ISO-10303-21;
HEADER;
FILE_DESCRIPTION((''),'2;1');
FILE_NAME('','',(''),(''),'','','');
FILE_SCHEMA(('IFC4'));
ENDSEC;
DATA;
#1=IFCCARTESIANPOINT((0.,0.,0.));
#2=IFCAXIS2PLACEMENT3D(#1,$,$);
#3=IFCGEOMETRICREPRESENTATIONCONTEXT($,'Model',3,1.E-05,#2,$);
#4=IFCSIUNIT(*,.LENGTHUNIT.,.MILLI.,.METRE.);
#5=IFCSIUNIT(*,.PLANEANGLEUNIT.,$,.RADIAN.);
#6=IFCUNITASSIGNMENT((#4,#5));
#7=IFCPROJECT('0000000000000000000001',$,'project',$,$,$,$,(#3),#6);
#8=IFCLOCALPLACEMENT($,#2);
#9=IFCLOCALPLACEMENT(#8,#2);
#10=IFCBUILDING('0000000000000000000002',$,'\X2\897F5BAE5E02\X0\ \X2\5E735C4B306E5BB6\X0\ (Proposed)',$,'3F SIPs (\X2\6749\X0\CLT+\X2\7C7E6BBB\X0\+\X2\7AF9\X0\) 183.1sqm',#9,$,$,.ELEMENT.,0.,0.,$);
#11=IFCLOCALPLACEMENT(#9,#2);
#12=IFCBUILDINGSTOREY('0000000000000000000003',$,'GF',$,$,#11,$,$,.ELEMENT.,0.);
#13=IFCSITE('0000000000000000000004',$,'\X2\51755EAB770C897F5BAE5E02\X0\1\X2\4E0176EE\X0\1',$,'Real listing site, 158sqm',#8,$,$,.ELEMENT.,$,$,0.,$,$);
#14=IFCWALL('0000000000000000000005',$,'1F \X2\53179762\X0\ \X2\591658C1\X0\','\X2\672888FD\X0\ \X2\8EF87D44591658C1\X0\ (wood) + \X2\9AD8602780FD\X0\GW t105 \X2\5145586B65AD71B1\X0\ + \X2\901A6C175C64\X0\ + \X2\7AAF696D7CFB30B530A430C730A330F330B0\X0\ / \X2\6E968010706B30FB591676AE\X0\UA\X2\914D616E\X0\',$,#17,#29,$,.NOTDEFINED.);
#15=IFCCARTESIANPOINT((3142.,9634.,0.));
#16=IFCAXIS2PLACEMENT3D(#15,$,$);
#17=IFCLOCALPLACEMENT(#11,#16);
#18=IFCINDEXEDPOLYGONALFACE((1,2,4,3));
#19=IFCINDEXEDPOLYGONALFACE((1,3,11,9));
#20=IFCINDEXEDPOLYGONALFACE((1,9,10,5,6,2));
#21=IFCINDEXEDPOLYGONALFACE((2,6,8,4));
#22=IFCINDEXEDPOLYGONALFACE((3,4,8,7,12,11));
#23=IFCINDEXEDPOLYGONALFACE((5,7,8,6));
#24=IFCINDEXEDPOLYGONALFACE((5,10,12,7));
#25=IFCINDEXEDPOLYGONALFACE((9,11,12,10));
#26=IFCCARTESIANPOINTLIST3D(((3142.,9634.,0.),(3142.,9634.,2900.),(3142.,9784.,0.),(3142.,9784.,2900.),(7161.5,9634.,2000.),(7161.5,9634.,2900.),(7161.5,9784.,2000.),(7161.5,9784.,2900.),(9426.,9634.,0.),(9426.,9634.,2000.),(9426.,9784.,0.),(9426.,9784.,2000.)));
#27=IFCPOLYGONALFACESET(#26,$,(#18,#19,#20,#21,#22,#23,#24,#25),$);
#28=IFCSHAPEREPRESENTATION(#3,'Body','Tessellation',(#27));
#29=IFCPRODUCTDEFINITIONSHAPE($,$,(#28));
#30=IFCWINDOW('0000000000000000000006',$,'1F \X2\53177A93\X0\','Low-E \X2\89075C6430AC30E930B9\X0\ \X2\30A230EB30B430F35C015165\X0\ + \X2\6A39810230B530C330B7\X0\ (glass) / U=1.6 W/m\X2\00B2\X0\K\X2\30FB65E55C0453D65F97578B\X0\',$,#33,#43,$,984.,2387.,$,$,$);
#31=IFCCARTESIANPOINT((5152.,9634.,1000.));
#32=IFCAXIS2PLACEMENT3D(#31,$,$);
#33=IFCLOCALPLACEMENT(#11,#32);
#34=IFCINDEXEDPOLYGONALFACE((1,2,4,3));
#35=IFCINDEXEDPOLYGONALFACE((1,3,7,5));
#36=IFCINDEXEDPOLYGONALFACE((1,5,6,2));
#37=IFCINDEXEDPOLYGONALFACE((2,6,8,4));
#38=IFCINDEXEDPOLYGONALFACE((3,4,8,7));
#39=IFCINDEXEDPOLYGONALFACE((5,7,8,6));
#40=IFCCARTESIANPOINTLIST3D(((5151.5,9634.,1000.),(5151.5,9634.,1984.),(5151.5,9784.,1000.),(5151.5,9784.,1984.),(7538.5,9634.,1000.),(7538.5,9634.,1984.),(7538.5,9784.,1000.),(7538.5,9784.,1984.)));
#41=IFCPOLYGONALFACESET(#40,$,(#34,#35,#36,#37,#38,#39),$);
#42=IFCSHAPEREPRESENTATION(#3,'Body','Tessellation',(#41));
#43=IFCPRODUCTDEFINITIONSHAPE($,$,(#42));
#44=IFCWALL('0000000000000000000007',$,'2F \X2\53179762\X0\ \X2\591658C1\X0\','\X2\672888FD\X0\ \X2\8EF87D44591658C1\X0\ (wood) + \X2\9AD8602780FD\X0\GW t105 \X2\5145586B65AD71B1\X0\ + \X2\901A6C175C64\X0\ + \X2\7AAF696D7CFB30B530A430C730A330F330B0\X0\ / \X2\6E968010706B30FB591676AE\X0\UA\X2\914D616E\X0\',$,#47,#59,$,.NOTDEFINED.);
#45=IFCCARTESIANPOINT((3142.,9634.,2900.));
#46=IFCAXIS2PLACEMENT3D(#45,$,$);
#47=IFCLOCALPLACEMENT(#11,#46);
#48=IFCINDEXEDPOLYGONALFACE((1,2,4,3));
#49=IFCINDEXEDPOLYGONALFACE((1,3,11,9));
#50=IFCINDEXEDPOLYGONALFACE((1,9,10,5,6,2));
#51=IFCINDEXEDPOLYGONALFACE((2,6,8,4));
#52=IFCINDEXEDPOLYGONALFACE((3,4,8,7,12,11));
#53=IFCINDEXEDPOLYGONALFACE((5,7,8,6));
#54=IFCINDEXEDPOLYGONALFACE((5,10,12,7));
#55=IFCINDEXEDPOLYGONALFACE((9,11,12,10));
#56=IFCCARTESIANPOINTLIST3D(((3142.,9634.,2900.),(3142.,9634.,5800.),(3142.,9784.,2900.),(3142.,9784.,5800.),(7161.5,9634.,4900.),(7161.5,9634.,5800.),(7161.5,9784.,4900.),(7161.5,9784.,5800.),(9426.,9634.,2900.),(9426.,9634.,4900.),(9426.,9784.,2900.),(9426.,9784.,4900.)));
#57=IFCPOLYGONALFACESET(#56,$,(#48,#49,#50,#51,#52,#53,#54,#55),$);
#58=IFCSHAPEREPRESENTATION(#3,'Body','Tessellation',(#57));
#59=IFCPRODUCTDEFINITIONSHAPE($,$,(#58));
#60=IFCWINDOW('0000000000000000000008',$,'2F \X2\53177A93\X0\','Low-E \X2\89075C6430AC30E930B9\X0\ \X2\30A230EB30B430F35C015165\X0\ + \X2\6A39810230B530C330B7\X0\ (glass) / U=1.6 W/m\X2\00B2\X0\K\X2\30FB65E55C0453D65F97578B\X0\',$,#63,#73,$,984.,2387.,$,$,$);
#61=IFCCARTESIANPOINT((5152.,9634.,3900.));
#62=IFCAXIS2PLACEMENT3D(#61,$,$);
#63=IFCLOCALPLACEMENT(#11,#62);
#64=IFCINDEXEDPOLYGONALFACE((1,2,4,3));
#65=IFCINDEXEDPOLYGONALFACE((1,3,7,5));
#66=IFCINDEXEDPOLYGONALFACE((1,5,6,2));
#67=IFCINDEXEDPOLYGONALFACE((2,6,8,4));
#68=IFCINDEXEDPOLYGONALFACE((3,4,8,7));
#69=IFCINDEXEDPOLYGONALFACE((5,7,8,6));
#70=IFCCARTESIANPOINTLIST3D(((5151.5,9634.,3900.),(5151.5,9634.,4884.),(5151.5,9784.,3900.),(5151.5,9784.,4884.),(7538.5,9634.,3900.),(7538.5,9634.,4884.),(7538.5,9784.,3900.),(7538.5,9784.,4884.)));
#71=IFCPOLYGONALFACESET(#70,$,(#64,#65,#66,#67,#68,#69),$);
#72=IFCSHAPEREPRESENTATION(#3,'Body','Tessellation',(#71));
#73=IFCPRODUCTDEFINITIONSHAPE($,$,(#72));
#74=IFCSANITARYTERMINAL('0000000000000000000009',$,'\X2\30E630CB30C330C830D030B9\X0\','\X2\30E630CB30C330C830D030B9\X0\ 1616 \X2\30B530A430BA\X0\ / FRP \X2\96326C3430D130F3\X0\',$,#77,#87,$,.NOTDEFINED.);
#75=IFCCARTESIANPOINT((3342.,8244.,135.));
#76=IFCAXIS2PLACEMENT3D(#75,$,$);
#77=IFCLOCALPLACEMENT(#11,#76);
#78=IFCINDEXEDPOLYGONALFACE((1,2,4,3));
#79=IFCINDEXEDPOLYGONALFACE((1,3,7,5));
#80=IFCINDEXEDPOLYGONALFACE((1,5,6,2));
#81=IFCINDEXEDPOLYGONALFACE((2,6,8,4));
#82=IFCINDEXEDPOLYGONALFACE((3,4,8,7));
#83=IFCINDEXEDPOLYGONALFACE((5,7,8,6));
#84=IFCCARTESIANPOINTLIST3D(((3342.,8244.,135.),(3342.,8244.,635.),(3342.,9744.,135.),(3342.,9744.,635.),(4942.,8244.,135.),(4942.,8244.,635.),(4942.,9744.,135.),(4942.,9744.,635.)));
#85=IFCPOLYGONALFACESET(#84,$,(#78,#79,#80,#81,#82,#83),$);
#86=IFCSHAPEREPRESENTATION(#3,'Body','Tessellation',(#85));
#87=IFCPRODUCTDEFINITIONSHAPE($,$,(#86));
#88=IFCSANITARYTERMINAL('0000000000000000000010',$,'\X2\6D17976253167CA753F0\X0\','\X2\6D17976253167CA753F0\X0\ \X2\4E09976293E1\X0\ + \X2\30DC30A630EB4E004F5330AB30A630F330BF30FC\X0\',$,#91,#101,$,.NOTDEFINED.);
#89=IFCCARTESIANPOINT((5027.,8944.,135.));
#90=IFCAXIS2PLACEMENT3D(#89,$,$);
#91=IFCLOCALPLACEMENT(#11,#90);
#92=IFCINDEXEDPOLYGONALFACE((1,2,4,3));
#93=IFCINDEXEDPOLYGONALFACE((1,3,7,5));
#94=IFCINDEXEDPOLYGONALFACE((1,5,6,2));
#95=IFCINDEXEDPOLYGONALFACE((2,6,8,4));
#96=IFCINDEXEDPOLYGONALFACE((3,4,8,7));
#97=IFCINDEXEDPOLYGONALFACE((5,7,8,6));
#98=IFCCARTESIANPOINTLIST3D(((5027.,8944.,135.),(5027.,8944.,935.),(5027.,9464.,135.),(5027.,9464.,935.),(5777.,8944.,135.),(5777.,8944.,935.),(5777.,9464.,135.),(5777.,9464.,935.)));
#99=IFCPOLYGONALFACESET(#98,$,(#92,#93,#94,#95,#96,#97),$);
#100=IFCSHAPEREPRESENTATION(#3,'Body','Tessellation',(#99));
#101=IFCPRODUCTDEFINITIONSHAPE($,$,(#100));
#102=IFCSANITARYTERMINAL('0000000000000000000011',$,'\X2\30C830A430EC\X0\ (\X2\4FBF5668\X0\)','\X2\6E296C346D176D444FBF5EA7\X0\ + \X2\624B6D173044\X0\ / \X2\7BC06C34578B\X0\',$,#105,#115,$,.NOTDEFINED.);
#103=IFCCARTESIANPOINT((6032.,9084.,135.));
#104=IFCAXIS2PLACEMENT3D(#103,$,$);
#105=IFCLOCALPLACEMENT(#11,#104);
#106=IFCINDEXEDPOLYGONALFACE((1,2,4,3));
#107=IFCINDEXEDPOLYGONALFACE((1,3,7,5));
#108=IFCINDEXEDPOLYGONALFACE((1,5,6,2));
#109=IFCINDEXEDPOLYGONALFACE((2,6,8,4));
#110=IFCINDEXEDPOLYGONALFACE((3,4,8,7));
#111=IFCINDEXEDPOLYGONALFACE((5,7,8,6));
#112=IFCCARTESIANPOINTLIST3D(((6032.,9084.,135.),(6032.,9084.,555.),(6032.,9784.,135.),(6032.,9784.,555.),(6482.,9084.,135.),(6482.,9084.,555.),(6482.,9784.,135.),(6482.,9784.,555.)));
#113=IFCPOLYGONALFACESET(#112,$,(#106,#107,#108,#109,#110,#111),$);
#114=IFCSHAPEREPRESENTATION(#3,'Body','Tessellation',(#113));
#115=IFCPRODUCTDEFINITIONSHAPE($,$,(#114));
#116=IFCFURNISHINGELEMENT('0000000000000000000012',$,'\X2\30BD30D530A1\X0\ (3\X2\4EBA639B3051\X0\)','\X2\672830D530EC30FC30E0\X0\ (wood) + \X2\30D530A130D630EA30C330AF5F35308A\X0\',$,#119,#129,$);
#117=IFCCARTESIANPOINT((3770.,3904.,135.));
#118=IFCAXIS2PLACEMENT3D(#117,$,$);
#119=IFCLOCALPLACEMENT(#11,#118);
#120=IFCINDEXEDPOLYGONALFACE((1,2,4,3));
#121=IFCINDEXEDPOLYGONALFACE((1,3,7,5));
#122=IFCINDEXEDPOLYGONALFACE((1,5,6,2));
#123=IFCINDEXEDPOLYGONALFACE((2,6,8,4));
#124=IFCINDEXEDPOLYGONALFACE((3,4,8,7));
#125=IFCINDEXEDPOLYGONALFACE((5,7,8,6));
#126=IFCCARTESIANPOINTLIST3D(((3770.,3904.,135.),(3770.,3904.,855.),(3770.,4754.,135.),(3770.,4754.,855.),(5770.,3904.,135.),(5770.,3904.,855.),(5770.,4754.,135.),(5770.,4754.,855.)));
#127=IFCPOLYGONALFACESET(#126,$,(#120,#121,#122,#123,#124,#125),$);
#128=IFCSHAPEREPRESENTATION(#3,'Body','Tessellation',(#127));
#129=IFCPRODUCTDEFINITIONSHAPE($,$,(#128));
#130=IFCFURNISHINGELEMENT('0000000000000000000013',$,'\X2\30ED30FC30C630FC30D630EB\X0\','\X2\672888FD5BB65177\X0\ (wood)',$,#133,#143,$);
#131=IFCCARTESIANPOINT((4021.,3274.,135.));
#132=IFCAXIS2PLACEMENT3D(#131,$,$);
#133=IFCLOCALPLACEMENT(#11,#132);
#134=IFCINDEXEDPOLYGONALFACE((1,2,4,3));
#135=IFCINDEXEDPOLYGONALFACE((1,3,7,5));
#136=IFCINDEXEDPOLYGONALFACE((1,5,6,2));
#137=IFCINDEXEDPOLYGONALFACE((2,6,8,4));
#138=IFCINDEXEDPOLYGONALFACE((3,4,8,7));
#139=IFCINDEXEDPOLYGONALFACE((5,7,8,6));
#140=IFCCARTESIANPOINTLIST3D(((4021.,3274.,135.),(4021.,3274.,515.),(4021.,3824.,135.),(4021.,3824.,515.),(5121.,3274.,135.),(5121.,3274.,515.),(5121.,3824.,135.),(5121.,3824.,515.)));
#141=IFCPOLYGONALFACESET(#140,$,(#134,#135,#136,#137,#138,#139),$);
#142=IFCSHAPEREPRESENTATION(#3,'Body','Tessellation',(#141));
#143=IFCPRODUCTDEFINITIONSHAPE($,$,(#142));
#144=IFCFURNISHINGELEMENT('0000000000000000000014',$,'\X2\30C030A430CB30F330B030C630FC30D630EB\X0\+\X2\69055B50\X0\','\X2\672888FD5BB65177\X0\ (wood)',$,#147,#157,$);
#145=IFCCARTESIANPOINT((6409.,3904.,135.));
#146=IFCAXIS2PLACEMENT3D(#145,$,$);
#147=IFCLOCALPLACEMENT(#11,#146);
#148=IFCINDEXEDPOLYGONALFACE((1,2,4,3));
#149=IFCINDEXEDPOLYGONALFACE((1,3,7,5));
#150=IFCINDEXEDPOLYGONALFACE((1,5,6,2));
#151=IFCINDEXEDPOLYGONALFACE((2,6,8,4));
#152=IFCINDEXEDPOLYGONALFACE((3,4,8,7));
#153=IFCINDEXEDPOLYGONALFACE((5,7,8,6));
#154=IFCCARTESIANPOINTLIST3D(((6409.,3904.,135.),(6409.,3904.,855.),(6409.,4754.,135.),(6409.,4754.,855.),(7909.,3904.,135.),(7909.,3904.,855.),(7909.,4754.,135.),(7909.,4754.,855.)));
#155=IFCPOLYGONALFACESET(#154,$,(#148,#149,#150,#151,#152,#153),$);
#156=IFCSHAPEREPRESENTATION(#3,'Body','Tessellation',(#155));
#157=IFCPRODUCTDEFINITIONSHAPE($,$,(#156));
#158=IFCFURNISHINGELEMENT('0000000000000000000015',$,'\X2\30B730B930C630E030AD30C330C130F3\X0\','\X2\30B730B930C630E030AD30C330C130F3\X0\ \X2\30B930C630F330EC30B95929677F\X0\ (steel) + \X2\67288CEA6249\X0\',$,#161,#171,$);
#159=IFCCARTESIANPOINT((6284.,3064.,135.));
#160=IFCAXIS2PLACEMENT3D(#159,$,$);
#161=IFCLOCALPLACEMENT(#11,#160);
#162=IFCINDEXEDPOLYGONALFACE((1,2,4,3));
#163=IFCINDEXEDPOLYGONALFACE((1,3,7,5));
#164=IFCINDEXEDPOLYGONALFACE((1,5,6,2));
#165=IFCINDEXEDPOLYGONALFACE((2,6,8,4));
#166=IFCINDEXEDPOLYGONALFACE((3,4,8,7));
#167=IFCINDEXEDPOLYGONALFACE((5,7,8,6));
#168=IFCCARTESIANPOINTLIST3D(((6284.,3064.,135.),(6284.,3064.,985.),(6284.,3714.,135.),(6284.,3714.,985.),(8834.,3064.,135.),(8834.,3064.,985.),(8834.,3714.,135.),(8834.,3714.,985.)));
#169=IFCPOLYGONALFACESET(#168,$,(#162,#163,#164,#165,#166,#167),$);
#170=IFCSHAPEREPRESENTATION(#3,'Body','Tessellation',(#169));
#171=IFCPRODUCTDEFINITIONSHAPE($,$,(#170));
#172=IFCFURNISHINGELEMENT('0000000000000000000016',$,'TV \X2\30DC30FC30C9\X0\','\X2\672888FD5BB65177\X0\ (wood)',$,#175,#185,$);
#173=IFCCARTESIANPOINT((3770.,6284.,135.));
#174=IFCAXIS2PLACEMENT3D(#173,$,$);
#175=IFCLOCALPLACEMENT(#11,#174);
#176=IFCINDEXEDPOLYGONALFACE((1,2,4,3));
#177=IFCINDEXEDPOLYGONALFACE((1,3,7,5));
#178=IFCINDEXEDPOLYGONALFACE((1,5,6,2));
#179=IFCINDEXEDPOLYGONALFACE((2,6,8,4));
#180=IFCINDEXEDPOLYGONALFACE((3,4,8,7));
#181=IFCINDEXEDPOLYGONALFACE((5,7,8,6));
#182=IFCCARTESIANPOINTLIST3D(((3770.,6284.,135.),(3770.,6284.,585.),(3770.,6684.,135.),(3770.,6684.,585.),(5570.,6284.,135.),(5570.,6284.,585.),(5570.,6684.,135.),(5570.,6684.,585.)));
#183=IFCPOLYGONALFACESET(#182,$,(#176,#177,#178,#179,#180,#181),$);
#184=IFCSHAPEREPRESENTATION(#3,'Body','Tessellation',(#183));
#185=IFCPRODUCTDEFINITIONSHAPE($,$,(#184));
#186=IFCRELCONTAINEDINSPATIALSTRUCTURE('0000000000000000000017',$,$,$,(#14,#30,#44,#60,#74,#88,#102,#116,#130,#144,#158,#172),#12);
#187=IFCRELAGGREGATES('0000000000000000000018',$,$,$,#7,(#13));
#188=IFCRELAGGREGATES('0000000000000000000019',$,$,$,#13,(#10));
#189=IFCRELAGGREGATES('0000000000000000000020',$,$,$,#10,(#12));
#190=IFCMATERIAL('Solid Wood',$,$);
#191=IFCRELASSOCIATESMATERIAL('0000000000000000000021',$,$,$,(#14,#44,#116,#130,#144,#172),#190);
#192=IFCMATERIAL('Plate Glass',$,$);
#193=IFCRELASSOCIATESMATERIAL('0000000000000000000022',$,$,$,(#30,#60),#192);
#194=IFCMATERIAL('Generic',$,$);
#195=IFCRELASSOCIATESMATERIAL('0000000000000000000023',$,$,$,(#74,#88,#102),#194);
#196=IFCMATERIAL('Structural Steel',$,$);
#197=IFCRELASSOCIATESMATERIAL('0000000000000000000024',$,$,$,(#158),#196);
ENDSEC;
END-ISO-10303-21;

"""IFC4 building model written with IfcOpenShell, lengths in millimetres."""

from ifc_helpers import new_model, si_unit, frame, frame_2d, origin, place, context, project, spatial, rectangle, extrude, material, element, fill, save


model = new_model("IFC4")

# Units and contexts
model_context = context("Model", 3, precision=1e-05, world=origin())
ifc_project = project(units=[si_unit("LENGTHUNIT", "METRE", prefix="MILLI"), si_unit("PLANEANGLEUNIT", "RADIAN")], contexts=[model_context])

# Site, building, storey
site_placement = place(None, origin())
site = spatial("IfcSite", under=ifc_project, at=site_placement, Name="兵庫県西宮市1丁目1", ObjectType="Real listing site, 158sqm", CompositionType="ELEMENT", RefElevation=0.0)
building_placement = place(site_placement, origin())
building = spatial("IfcBuilding", under=site, at=building_placement, Name="西宮市 平屋の家 (Proposed)", ObjectType="3F SIPs (杉CLT+籾殻+竹) 183.1sqm", CompositionType="ELEMENT", ElevationOfRefHeight=0.0, ElevationOfTerrain=0.0)
storey_placement = place(building_placement, origin())
storey = spatial("IfcBuildingStorey", under=building, at=storey_placement, Name="GF", CompositionType="ELEMENT", Elevation=0.0)

# Wall, opening, window
ifc_material_1 = material(Name="Solid Wood")
wall_1_placement = place(storey_placement, frame((3142.0, 9634.0, 0.0)))
wall_1 = element("IfcWall", 1, at=wall_1_placement, inside=storey, material=ifc_material_1, Name="1F 北面 外壁", Description="木製 軸組外壁 (wood) + 高性能GW t105 充填断熱 + 通気層 + 窯業系サイディング / 準耐火・外皮UA配慮", PredefinedType="NOTDEFINED", context=model_context, shape_type="SweptSolid", body=[
    extrude(rectangle(XDim=6284.0, YDim=150.0, at=frame_2d((3142.0, 75.0))), frame((3142.0, 9634.0, 0.0)), (0.0, 0.0, 1.0), 2900.0),
])
opening_1_placement = place(storey_placement, frame((5152.0, 9634.0, 1000.0)))
opening_1 = element("IfcOpeningElement", 2, at=opening_1_placement, cuts=wall_1, PredefinedType="NOTDEFINED", context=model_context, shape_type="SweptSolid", body=[
    extrude(rectangle(XDim=2387.0, YDim=150.0, at=frame_2d((1193.0, 75.0))), frame((5152.0, 9634.0, 1000.0)), (0.0, 0.0, 1.0), 984.0),
])
ifc_material_2 = material(Name="Plate Glass")
window_1_placement = place(storey_placement, frame((5152.0, 9634.0, 1000.0)))
window_1 = element("IfcWindow", 3, at=window_1_placement, inside=storey, material=ifc_material_2, Name="1F 北窓", Description="Low-E 複層ガラス アルゴン封入 + 樹脂サッシ (glass) / U=1.6 W/m²K・日射取得型", OverallHeight=984.0, OverallWidth=2387.0, context=model_context, shape_type="SweptSolid", body=[
    extrude(rectangle(XDim=2387.0, YDim=150.0, at=frame_2d((1193.0, 75.0))), frame((5152.0, 9634.0, 1000.0)), (0.0, 0.0, 1.0), 984.0),
])
fill(opening_1, window_1)

# Wall, opening, window
wall_2_placement = place(storey_placement, frame((3142.0, 9634.0, 2900.0)))
wall_2 = element("IfcWall", 4, at=wall_2_placement, inside=storey, material=ifc_material_1, Name="2F 北面 外壁", Description="木製 軸組外壁 (wood) + 高性能GW t105 充填断熱 + 通気層 + 窯業系サイディング / 準耐火・外皮UA配慮", PredefinedType="NOTDEFINED", context=model_context, shape_type="SweptSolid", body=[
    extrude(rectangle(XDim=6284.0, YDim=150.0, at=frame_2d((3142.0, 75.0))), frame((3142.0, 9634.0, 2900.0)), (0.0, 0.0, 1.0), 2900.0),
])
opening_2_placement = place(storey_placement, frame((5152.0, 9634.0, 3900.0)))
opening_2 = element("IfcOpeningElement", 5, at=opening_2_placement, cuts=wall_2, PredefinedType="NOTDEFINED", context=model_context, shape_type="SweptSolid", body=[
    extrude(rectangle(XDim=2387.0, YDim=150.0, at=frame_2d((1193.0, 75.0))), frame((5152.0, 9634.0, 3900.0)), (0.0, 0.0, 1.0), 984.0),
])
window_2_placement = place(storey_placement, frame((5152.0, 9634.0, 3900.0)))
window_2 = element("IfcWindow", 6, at=window_2_placement, inside=storey, material=ifc_material_2, Name="2F 北窓", Description="Low-E 複層ガラス アルゴン封入 + 樹脂サッシ (glass) / U=1.6 W/m²K・日射取得型", OverallHeight=984.0, OverallWidth=2387.0, context=model_context, shape_type="SweptSolid", body=[
    extrude(rectangle(XDim=2387.0, YDim=150.0, at=frame_2d((1193.0, 75.0))), frame((5152.0, 9634.0, 3900.0)), (0.0, 0.0, 1.0), 984.0),
])
fill(opening_2, window_2)

# Sanitary terminals
ifc_material_3 = material(Name="Generic")
sanitary_terminal_1_placement = place(storey_placement, frame((3342.0, 8244.0, 135.0)))
element("IfcSanitaryTerminal", 7, at=sanitary_terminal_1_placement, inside=storey, material=ifc_material_3, Name="ユニットバス", Description="ユニットバス 1616 サイズ / FRP 防水パン", PredefinedType="NOTDEFINED", context=model_context, shape_type="SweptSolid", body=[
    extrude(rectangle(XDim=1600.0, YDim=1500.0, at=frame_2d((800.0, 750.0))), frame((3342.0, 8244.0, 135.0)), (0.0, 0.0, 1.0), 500.0),
])
sanitary_terminal_2_placement = place(storey_placement, frame((5027.0, 8944.0, 135.0)))
element("IfcSanitaryTerminal", 8, at=sanitary_terminal_2_placement, inside=storey, material=ifc_material_3, Name="洗面化粧台", Description="洗面化粧台 三面鏡 + ボウル一体カウンター", PredefinedType="NOTDEFINED", context=model_context, shape_type="SweptSolid", body=[
    extrude(rectangle(XDim=750.0, YDim=520.0, at=frame_2d((375.0, 260.0))), frame((5027.0, 8944.0, 135.0)), (0.0, 0.0, 1.0), 800.0),
])
sanitary_terminal_3_placement = place(storey_placement, frame((6032.0, 9084.0, 135.0)))
element("IfcSanitaryTerminal", 9, at=sanitary_terminal_3_placement, inside=storey, material=ifc_material_3, Name="トイレ (便器)", Description="温水洗浄便座 + 手洗い / 節水型", PredefinedType="NOTDEFINED", context=model_context, shape_type="SweptSolid", body=[
    extrude(rectangle(XDim=450.0, YDim=700.0, at=frame_2d((225.0, 350.0))), frame((6032.0, 9084.0, 135.0)), (0.0, 0.0, 1.0), 420.0),
])

# Furnishing elements
furnishing_1_placement = place(storey_placement, frame((3770.0, 3904.0, 135.0)))
element("IfcFurnishingElement", 10, at=furnishing_1_placement, inside=storey, material=ifc_material_1, Name="ソファ (3人掛け)", Description="木フレーム (wood) + ファブリック張り", context=model_context, shape_type="SweptSolid", body=[
    extrude(rectangle(XDim=2000.0, YDim=850.0, at=frame_2d((1000.0, 425.0))), frame((3770.0, 3904.0, 135.0)), (0.0, 0.0, 1.0), 720.0),
])
furnishing_2_placement = place(storey_placement, frame((4021.0, 3274.0, 135.0)))
element("IfcFurnishingElement", 11, at=furnishing_2_placement, inside=storey, material=ifc_material_1, Name="ローテーブル", Description="木製家具 (wood)", context=model_context, shape_type="SweptSolid", body=[
    extrude(rectangle(XDim=1100.0, YDim=550.0, at=frame_2d((550.0, 275.0))), frame((4021.0, 3274.0, 135.0)), (0.0, 0.0, 1.0), 380.0),
])
furnishing_3_placement = place(storey_placement, frame((6409.0, 3904.0, 135.0)))
element("IfcFurnishingElement", 12, at=furnishing_3_placement, inside=storey, material=ifc_material_1, Name="ダイニングテーブル+椅子", Description="木製家具 (wood)", context=model_context, shape_type="SweptSolid", body=[
    extrude(rectangle(XDim=1500.0, YDim=850.0, at=frame_2d((750.0, 425.0))), frame((6409.0, 3904.0, 135.0)), (0.0, 0.0, 1.0), 720.0),
])
ifc_material_4 = material(Name="Structural Steel")
furnishing_4_placement = place(storey_placement, frame((6284.0, 3064.0, 135.0)))
element("IfcFurnishingElement", 13, at=furnishing_4_placement, inside=storey, material=ifc_material_4, Name="システムキッチン", Description="システムキッチン ステンレス天板 (steel) + 木質扉", context=model_context, shape_type="SweptSolid", body=[
    extrude(rectangle(XDim=2550.0, YDim=650.0, at=frame_2d((1275.0, 325.0))), frame((6284.0, 3064.0, 135.0)), (0.0, 0.0, 1.0), 850.0),
])
furnishing_5_placement = place(storey_placement, frame((3770.0, 6284.0, 135.0)))
element("IfcFurnishingElement", 14, at=furnishing_5_placement, inside=storey, material=ifc_material_1, Name="TV ボード", Description="木製家具 (wood)", context=model_context, shape_type="SweptSolid", body=[
    extrude(rectangle(XDim=1800.0, YDim=400.0, at=frame_2d((900.0, 200.0))), frame((3770.0, 6284.0, 135.0)), (0.0, 0.0, 1.0), 450.0),
])

save(model, "model.ifc")
